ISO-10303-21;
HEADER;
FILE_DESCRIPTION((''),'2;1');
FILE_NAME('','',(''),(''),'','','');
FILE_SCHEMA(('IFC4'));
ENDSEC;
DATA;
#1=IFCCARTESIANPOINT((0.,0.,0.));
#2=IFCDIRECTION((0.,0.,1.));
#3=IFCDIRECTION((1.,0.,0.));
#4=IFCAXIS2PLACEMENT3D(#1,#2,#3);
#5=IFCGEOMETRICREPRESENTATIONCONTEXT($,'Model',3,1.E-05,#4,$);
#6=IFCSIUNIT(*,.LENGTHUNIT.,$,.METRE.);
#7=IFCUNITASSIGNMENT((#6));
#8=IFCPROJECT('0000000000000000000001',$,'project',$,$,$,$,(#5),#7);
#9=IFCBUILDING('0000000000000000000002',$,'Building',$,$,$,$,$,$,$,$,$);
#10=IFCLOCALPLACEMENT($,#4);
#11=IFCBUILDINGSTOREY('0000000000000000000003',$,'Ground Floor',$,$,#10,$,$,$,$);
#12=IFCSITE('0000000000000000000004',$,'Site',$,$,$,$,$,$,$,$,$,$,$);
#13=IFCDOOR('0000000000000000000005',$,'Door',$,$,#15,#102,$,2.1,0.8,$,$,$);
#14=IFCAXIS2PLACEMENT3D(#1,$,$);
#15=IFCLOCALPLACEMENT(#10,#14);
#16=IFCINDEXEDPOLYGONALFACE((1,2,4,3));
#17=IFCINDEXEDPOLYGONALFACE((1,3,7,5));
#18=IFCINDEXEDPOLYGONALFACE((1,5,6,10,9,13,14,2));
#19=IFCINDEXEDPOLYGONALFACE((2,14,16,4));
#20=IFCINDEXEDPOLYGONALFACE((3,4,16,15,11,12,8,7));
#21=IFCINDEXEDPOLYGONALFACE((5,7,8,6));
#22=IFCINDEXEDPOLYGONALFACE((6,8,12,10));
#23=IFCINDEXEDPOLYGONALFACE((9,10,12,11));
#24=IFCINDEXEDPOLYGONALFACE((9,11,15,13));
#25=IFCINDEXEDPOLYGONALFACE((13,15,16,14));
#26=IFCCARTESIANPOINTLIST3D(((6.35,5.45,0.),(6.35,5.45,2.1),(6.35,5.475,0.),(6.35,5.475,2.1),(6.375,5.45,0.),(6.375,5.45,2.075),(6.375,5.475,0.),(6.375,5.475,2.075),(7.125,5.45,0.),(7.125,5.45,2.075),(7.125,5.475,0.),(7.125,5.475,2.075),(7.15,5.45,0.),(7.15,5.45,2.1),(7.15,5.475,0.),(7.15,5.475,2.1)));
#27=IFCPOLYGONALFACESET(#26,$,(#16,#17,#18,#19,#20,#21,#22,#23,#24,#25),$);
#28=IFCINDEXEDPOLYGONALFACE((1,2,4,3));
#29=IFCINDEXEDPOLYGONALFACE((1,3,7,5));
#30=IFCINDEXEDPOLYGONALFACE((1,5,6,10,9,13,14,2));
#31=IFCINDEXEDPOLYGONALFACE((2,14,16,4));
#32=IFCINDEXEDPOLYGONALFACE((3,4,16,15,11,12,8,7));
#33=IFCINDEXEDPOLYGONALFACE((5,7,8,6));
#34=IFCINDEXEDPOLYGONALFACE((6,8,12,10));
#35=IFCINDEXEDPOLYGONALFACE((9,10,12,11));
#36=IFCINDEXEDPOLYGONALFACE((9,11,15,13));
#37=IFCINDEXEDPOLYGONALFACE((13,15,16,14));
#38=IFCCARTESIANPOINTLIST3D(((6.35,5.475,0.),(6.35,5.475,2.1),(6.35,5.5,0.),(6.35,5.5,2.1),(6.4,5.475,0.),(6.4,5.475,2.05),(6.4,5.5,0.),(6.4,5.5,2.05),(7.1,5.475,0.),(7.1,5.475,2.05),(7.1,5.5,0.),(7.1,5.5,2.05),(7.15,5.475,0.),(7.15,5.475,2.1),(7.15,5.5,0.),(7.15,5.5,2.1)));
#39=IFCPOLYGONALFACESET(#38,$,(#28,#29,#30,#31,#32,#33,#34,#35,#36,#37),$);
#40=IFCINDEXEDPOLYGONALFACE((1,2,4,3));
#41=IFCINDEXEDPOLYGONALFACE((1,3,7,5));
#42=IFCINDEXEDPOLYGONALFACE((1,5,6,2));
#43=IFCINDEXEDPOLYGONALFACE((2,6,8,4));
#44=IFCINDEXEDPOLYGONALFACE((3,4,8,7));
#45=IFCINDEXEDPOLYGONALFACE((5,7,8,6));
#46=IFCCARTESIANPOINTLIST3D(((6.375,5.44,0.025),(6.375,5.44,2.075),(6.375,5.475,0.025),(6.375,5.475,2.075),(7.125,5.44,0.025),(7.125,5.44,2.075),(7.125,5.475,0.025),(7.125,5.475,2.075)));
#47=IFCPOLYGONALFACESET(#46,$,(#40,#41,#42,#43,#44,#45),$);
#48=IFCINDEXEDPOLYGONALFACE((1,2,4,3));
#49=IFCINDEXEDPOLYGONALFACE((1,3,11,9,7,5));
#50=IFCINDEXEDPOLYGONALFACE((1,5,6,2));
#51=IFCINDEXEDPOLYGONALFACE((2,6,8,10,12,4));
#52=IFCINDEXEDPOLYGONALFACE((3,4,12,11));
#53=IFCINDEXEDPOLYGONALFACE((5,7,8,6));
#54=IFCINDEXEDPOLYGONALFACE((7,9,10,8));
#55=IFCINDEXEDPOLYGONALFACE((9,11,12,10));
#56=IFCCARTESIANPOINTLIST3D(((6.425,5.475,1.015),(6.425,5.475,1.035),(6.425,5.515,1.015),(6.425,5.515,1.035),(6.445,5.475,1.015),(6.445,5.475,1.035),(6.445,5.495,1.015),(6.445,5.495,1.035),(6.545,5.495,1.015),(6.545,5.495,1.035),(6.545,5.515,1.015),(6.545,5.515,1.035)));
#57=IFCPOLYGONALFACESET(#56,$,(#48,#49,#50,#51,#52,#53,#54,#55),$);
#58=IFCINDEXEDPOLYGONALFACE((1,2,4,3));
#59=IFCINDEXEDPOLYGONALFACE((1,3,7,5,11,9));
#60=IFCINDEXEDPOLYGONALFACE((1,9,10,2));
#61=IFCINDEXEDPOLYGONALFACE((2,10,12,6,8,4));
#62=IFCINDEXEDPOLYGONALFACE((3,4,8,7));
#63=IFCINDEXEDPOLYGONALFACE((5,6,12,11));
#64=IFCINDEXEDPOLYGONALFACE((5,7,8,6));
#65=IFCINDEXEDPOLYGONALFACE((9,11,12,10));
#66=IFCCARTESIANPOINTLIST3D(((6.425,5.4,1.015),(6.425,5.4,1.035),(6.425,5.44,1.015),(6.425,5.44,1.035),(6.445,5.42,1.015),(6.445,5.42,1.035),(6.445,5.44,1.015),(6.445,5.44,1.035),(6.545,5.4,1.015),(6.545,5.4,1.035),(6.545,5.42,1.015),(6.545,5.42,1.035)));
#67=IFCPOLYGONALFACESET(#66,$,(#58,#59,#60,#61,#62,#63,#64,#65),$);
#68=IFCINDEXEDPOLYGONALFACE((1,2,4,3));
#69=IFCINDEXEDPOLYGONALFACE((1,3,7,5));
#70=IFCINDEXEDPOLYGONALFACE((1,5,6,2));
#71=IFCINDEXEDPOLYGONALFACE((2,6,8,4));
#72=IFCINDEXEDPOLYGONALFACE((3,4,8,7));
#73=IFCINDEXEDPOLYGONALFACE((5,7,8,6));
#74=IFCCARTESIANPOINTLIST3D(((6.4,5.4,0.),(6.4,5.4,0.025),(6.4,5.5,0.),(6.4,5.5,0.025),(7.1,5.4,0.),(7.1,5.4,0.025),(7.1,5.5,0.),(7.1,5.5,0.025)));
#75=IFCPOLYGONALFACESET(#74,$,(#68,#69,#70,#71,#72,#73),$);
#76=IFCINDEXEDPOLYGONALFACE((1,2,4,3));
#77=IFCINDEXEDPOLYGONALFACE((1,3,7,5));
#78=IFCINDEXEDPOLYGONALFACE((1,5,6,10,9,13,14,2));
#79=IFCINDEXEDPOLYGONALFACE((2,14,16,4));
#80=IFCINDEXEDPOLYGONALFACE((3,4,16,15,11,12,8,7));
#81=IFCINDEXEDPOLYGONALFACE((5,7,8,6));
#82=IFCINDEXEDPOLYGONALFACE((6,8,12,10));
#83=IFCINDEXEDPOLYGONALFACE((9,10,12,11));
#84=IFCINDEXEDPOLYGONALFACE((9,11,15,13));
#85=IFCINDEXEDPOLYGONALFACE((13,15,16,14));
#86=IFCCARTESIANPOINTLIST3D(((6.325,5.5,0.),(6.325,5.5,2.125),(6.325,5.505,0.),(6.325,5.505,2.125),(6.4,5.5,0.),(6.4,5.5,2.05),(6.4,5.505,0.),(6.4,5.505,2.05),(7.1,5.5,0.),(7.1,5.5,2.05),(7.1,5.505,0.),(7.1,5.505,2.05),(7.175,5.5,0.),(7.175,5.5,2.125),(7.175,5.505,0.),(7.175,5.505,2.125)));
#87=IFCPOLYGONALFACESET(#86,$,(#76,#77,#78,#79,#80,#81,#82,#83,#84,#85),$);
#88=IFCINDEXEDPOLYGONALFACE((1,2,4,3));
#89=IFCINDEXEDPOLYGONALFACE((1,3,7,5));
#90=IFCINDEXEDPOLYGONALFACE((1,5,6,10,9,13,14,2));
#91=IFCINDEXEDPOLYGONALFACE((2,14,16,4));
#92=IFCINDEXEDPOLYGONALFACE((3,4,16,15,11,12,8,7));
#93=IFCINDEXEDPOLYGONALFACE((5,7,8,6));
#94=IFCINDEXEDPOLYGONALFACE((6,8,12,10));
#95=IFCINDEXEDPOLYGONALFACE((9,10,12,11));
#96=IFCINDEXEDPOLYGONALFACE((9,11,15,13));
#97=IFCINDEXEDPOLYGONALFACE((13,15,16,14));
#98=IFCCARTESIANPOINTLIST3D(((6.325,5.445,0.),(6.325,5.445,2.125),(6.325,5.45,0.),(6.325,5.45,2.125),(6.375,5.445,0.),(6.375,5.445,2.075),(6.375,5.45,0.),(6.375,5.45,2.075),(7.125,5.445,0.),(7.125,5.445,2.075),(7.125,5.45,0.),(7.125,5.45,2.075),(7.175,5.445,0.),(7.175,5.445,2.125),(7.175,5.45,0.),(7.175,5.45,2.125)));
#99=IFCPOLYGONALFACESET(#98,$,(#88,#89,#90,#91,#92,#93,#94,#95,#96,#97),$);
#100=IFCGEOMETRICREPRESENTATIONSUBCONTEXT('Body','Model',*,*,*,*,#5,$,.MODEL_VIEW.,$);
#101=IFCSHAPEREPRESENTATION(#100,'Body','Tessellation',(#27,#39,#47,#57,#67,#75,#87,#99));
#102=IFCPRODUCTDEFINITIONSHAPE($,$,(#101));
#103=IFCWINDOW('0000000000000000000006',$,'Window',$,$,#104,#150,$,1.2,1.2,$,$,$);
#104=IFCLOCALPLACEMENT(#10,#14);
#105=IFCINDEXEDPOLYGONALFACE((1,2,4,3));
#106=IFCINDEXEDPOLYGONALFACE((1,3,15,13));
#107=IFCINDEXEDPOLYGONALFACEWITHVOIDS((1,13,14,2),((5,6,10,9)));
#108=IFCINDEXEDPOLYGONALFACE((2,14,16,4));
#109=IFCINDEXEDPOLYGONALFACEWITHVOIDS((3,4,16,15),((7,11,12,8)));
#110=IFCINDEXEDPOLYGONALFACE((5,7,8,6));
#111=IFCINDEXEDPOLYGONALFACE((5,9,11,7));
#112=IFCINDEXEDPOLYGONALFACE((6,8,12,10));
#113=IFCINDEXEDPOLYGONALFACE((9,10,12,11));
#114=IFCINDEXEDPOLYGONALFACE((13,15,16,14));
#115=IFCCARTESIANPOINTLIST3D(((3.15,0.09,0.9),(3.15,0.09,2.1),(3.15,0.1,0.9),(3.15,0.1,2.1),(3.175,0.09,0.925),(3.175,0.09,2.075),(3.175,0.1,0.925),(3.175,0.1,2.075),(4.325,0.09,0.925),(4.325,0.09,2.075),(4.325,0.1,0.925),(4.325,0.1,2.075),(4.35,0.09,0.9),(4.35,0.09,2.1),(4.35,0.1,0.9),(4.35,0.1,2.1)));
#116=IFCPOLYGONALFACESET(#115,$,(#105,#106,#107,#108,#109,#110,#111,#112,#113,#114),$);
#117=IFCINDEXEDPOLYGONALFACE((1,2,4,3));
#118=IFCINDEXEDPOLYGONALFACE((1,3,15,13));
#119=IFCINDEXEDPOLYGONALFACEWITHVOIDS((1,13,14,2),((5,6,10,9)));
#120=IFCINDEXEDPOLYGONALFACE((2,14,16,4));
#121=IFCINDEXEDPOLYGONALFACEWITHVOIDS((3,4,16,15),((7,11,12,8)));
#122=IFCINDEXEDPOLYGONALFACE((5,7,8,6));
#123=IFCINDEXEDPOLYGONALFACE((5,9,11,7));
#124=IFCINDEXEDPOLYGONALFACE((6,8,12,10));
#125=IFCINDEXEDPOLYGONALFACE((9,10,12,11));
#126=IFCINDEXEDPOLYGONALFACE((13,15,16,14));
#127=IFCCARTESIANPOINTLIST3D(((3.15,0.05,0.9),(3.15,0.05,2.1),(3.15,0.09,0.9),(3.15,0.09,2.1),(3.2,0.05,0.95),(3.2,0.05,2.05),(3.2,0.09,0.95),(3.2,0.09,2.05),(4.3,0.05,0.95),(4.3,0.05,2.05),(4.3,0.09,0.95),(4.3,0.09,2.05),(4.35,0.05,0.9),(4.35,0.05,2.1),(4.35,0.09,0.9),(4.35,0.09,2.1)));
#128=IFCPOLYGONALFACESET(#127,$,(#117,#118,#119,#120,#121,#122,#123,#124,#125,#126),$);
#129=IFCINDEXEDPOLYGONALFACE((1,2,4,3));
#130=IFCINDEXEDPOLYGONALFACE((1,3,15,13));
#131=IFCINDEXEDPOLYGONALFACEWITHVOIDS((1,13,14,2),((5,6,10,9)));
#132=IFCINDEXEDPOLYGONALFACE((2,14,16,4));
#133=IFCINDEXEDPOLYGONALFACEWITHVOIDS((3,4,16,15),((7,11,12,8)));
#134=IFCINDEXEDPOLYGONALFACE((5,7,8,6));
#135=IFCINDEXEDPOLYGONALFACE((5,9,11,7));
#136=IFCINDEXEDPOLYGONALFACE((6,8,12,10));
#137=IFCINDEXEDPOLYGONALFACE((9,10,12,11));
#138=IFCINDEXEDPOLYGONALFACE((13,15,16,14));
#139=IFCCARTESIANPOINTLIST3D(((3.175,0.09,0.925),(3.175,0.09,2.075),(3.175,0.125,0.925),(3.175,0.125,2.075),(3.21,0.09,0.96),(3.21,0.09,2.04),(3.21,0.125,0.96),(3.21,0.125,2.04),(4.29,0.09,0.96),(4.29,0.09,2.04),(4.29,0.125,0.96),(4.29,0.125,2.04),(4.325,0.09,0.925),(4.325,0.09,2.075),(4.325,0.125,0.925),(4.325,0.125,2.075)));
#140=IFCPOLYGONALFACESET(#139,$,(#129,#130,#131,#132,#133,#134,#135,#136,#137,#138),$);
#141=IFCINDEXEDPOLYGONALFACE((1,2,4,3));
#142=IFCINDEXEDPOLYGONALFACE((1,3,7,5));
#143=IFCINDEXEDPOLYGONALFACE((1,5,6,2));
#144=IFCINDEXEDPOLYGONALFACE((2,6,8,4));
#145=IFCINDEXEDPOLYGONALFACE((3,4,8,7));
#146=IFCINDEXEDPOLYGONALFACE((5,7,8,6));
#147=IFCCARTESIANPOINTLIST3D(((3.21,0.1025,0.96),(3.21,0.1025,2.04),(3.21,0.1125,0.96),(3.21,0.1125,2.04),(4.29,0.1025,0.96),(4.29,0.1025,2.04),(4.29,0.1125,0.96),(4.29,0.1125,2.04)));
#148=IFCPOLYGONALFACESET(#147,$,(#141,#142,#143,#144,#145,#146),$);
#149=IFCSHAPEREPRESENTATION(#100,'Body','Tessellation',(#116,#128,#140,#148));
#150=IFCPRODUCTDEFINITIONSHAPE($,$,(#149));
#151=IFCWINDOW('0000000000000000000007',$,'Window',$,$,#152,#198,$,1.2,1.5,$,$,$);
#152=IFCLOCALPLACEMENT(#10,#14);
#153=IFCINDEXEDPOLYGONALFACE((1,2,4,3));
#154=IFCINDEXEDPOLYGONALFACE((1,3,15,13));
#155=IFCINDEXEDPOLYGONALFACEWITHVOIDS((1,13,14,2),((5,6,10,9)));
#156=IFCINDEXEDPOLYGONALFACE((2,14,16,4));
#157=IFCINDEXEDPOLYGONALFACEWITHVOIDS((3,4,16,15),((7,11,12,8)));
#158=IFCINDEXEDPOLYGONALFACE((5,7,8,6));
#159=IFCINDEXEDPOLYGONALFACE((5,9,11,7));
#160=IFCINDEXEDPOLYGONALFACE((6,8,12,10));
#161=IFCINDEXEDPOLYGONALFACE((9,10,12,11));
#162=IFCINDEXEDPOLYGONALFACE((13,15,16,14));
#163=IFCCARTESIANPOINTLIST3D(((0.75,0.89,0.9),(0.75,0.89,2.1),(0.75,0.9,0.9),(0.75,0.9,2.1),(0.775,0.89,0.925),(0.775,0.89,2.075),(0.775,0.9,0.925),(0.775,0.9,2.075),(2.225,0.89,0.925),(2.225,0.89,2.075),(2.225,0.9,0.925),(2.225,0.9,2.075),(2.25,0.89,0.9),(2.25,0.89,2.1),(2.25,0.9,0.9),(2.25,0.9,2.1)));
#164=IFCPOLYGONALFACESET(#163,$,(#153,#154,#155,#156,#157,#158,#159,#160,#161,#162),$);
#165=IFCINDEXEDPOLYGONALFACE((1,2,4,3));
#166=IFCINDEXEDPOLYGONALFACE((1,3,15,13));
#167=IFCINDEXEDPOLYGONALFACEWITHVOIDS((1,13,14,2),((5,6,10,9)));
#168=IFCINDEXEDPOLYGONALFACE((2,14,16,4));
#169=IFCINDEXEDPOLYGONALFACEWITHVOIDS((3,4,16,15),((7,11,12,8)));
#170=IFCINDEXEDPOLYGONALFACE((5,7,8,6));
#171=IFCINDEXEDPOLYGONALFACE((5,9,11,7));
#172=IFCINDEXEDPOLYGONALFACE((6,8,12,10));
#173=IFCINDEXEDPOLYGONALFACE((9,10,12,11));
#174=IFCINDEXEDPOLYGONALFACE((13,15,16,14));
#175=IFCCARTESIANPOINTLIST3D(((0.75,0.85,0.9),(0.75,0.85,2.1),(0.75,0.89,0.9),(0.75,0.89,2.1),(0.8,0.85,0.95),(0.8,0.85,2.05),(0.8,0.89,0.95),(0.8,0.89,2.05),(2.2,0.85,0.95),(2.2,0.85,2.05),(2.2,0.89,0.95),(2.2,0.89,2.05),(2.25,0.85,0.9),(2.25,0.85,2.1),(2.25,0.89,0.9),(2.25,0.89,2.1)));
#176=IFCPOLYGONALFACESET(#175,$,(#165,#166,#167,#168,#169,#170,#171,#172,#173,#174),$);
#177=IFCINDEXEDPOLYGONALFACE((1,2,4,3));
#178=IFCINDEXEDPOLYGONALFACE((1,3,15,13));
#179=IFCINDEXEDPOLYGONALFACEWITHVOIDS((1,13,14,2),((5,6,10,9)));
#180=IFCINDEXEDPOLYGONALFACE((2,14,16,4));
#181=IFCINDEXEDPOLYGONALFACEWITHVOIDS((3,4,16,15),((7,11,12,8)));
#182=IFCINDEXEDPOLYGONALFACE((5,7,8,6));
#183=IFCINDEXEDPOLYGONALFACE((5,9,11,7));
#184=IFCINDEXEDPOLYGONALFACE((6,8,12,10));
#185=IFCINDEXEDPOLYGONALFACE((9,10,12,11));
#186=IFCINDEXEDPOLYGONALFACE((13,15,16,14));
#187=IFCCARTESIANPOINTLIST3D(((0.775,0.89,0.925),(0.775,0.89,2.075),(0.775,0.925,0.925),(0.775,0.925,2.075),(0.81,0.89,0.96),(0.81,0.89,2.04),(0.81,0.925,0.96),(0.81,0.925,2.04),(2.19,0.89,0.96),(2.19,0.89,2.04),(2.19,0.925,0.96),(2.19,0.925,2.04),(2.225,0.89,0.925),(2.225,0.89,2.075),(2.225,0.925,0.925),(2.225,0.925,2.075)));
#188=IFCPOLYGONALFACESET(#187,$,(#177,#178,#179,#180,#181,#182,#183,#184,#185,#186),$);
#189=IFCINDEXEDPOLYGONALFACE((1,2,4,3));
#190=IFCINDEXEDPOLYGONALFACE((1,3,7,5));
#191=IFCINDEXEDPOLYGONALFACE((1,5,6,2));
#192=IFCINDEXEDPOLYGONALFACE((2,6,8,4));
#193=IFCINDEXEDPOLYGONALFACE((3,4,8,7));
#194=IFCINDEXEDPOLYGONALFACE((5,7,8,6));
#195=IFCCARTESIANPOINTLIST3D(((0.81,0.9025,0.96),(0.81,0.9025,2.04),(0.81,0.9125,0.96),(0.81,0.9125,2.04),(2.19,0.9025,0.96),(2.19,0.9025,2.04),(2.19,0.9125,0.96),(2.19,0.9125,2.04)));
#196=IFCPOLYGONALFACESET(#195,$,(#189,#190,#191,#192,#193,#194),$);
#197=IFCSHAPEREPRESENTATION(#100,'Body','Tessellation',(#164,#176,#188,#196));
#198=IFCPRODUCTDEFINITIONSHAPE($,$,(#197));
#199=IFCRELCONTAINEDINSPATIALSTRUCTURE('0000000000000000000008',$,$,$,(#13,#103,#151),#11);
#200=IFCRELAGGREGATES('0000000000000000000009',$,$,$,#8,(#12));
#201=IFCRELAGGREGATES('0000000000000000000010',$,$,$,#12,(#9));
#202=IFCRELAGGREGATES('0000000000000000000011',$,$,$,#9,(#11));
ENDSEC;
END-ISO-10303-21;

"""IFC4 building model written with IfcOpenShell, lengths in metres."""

from ifc_helpers import new_model, si_unit, frame, origin_with_axes, place, context, subcontext, project, spatial, line, indexed_curve, outline, extrude, element, save


model = new_model("IFC4")

# Units and contexts
model_context = context("Model", 3, precision=1e-05, world=origin_with_axes())
body_context = subcontext(model_context, "Body", "Model", "MODEL_VIEW")
ifc_project = project(units=[si_unit("LENGTHUNIT", "METRE")], contexts=[model_context])

# Site, building, storey
site = spatial("IfcSite", under=ifc_project, Name="Site")
building = spatial("IfcBuilding", under=site, Name="Building")
storey_placement = place(None, origin_with_axes())
storey = spatial("IfcBuildingStorey", under=building, at=storey_placement, Name="Ground Floor")

# Door
door_1_placement = place(storey_placement, frame((7.15, 5.5, 0.0), z_axis=(0.0, 0.0, 1.0), x_axis=(-1.0, 0.0, 0.0)))
element("IfcDoor", 1, at=door_1_placement, inside=storey, Name="Door", OverallHeight=2.1, OverallWidth=0.8, context=body_context, shape_type="SweptSolid", body=[
    extrude(outline(indexed_curve([(0.0, 0.0), (0.0, 2.1), (0.8, 2.1), (0.8, 0.0), (0.775, 0.0), (0.775, 2.075), (0.025, 2.075), (0.025, 0.0)], segments=[line(1, 2, 3, 4, 5, 6, 7, 8, 1)])), frame((0.0, 0.025, 0.0), z_axis=(0.0, -1.0, 0.0), x_axis=(1.0, 0.0, 0.0)), (0.0, 0.0, -1.0), 0.025),
    extrude(outline(indexed_curve([(0.0, 0.0), (0.0, 2.1), (0.8, 2.1), (0.8, 0.0), (0.75, 0.0), (0.75, 2.05), (0.05, 2.05), (0.05, 0.0)], segments=[line(1, 2, 3, 4, 5, 6, 7, 8, 1)])), frame((0.0, 0.0, 0.0), z_axis=(0.0, -1.0, 0.0), x_axis=(1.0, 0.0, 0.0)), (0.0, 0.0, -1.0), 0.025),
    extrude(outline(indexed_curve([(0.0, 0.0), (0.75, 0.0), (0.75, 0.035), (0.0, 0.035)], segments=[line(1, 2, 3, 4, 1)])), frame((0.025, 0.025, 0.025), z_axis=(0.0, 0.0, 1.0), x_axis=(1.0, 0.0, 0.0)), (0.0, 0.0, 1.0), 2.05),
    extrude(outline(indexed_curve([(0.0, 0.0), (0.0, -0.04), (-0.12, -0.04), (-0.12, -0.02), (-0.02, -0.02), (-0.02, 0.0)], segments=[line(1, 2, 3, 4, 5, 6, 1)])), frame((0.725, 0.025, 1.015), z_axis=(0.0, 0.0, 1.0), x_axis=(1.0, 0.0, 0.0)), (0.0, 0.0, 1.0), 0.02),
    extrude(outline(indexed_curve([(0.0, 0.0), (0.0, 0.04), (-0.12, 0.04), (-0.12, 0.02), (-0.02, 0.02), (-0.02, 0.0)], segments=[line(1, 2, 3, 4, 5, 6, 1)])), frame((0.725, 0.06, 1.015), z_axis=(0.0, 0.0, 1.0), x_axis=(1.0, 0.0, 0.0)), (0.0, 0.0, 1.0), 0.02),
    extrude(outline(indexed_curve([(0.0, 0.0), (0.7, 0.0), (0.7, 0.1), (0.0, 0.1)], segments=[line(1, 2, 3, 4, 1)])), frame((0.05, 0.0, 0.0), z_axis=(0.0, 0.0, 1.0), x_axis=(1.0, 0.0, 0.0)), (0.0, 0.0, 1.0), 0.025),
    extrude(outline(indexed_curve([(0.0, 0.0), (0.0, 2.125), (0.85, 2.125), (0.85, 0.0), (0.775, 0.0), (0.775, 2.05), (0.075, 2.05), (0.075, 0.0)], segments=[line(1, 2, 3, 4, 5, 6, 7, 8, 1)])), frame((-0.025, -0.005, 0.0), z_axis=(0.0, -1.0, 0.0), x_axis=(1.0, 0.0, 0.0)), (0.0, 0.0, -1.0), 0.005),
    extrude(outline(indexed_curve([(0.0, 0.0), (0.0, 2.125), (0.85, 2.125), (0.85, 0.0), (0.8, 0.0), (0.8, 2.075), (0.05, 2.075), (0.05, 0.0)], segments=[line(1, 2, 3, 4, 5, 6, 7, 8, 1)])), frame((-0.025, 0.05, 0.0), z_axis=(0.0, -1.0, 0.0), x_axis=(1.0, 0.0, 0.0)), (0.0, 0.0, -1.0), 0.005),
])

# Windows
window_1_placement = place(storey_placement, frame((3.15, 0.0, 0.9), z_axis=(0.0, 0.0, 1.0), x_axis=(1.0, 0.0, 0.0)))
element("IfcWindow", 2, at=window_1_placement, inside=storey, Name="Window", OverallHeight=1.2, OverallWidth=1.2, context=body_context, shape_type="SweptSolid", body=[
    extrude(outline(indexed_curve([(0.0, 0.0), (1.2, 0.0), (1.2, 1.2), (0.0, 1.2)], segments=[line(1, 2, 3, 4, 1)]), holes=[indexed_curve([(0.025, 0.025), (1.175, 0.025), (1.175, 1.175), (0.025, 1.175)], segments=[line(1, 2, 3, 4, 1)])]), frame((0.0, 0.09, 0.0), z_axis=(0.0, -1.0, 0.0), x_axis=(1.0, 0.0, 0.0)), (0.0, 0.0, -1.0), 0.01),
    extrude(outline(indexed_curve([(0.0, 0.0), (1.2, 0.0), (1.2, 1.2), (0.0, 1.2)], segments=[line(1, 2, 3, 4, 1)]), holes=[indexed_curve([(0.05, 0.05), (1.15, 0.05), (1.15, 1.15), (0.05, 1.15)], segments=[line(1, 2, 3, 4, 1)])]), frame((0.0, 0.05, 0.0), z_axis=(0.0, -1.0, 0.0), x_axis=(1.0, 0.0, 0.0)), (0.0, 0.0, -1.0), 0.04),
    extrude(outline(indexed_curve([(0.0, 0.0), (1.15, 0.0), (1.15, 1.15), (0.0, 1.15)], segments=[line(1, 2, 3, 4, 1)]), holes=[indexed_curve([(0.035, 0.035), (1.115, 0.035), (1.115, 1.115), (0.035, 1.115)], segments=[line(1, 2, 3, 4, 1)])]), frame((0.025, 0.09, 0.025), z_axis=(0.0, -1.0, 0.0), x_axis=(1.0, 0.0, 0.0)), (0.0, 0.0, -1.0), 0.035),
    extrude(outline(indexed_curve([(0.035, 0.035), (1.115, 0.035), (1.115, 1.115), (0.035, 1.115)], segments=[line(1, 2, 3, 4, 1)])), frame((0.025, 0.1025, 0.025), z_axis=(0.0, -1.0, 0.0), x_axis=(1.0, 0.0, 0.0)), (0.0, 0.0, -1.0), 0.01),
])
for number, where, z_axis, x_axis, name in (
    (3, (0.75, 0.8, 0.9), (0.0, 0.0, 1.0), (1.0, 0.0, 0.0), "Window"),
):
    element("IfcWindow", number, at=place(storey_placement, frame(where, z_axis=z_axis, x_axis=x_axis)), inside=storey, Name=name, OverallHeight=1.2, OverallWidth=1.5, context=body_context, shape_type="SweptSolid", body=[
        extrude(outline(indexed_curve([(0.0, 0.0), (1.5, 0.0), (1.5, 1.2), (0.0, 1.2)], segments=[line(1, 2, 3, 4, 1)]), holes=[indexed_curve([(0.025, 0.025), (1.475, 0.025), (1.475, 1.175), (0.025, 1.175)], segments=[line(1, 2, 3, 4, 1)])]), frame((0.0, 0.09, 0.0), z_axis=(0.0, -1.0, 0.0), x_axis=(1.0, 0.0, 0.0)), (0.0, 0.0, -1.0), 0.01),
        extrude(outline(indexed_curve([(0.0, 0.0), (1.5, 0.0), (1.5, 1.2), (0.0, 1.2)], segments=[line(1, 2, 3, 4, 1)]), holes=[indexed_curve([(0.05, 0.05), (1.45, 0.05), (1.45, 1.15), (0.05, 1.15)], segments=[line(1, 2, 3, 4, 1)])]), frame((0.0, 0.05, 0.0), z_axis=(0.0, -1.0, 0.0), x_axis=(1.0, 0.0, 0.0)), (0.0, 0.0, -1.0), 0.04),
        extrude(outline(indexed_curve([(0.0, 0.0), (1.45, 0.0), (1.45, 1.15), (0.0, 1.15)], segments=[line(1, 2, 3, 4, 1)]), holes=[indexed_curve([(0.035, 0.035), (1.415, 0.035), (1.415, 1.115), (0.035, 1.115)], segments=[line(1, 2, 3, 4, 1)])]), frame((0.025, 0.09, 0.025), z_axis=(0.0, -1.0, 0.0), x_axis=(1.0, 0.0, 0.0)), (0.0, 0.0, -1.0), 0.035),
        extrude(outline(indexed_curve([(0.035, 0.035), (1.415, 0.035), (1.415, 1.115), (0.035, 1.115)], segments=[line(1, 2, 3, 4, 1)])), frame((0.025, 0.1025, 0.025), z_axis=(0.0, -1.0, 0.0), x_axis=(1.0, 0.0, 0.0)), (0.0, 0.0, -1.0), 0.01),
    ])

save(model, "model.ifc")
